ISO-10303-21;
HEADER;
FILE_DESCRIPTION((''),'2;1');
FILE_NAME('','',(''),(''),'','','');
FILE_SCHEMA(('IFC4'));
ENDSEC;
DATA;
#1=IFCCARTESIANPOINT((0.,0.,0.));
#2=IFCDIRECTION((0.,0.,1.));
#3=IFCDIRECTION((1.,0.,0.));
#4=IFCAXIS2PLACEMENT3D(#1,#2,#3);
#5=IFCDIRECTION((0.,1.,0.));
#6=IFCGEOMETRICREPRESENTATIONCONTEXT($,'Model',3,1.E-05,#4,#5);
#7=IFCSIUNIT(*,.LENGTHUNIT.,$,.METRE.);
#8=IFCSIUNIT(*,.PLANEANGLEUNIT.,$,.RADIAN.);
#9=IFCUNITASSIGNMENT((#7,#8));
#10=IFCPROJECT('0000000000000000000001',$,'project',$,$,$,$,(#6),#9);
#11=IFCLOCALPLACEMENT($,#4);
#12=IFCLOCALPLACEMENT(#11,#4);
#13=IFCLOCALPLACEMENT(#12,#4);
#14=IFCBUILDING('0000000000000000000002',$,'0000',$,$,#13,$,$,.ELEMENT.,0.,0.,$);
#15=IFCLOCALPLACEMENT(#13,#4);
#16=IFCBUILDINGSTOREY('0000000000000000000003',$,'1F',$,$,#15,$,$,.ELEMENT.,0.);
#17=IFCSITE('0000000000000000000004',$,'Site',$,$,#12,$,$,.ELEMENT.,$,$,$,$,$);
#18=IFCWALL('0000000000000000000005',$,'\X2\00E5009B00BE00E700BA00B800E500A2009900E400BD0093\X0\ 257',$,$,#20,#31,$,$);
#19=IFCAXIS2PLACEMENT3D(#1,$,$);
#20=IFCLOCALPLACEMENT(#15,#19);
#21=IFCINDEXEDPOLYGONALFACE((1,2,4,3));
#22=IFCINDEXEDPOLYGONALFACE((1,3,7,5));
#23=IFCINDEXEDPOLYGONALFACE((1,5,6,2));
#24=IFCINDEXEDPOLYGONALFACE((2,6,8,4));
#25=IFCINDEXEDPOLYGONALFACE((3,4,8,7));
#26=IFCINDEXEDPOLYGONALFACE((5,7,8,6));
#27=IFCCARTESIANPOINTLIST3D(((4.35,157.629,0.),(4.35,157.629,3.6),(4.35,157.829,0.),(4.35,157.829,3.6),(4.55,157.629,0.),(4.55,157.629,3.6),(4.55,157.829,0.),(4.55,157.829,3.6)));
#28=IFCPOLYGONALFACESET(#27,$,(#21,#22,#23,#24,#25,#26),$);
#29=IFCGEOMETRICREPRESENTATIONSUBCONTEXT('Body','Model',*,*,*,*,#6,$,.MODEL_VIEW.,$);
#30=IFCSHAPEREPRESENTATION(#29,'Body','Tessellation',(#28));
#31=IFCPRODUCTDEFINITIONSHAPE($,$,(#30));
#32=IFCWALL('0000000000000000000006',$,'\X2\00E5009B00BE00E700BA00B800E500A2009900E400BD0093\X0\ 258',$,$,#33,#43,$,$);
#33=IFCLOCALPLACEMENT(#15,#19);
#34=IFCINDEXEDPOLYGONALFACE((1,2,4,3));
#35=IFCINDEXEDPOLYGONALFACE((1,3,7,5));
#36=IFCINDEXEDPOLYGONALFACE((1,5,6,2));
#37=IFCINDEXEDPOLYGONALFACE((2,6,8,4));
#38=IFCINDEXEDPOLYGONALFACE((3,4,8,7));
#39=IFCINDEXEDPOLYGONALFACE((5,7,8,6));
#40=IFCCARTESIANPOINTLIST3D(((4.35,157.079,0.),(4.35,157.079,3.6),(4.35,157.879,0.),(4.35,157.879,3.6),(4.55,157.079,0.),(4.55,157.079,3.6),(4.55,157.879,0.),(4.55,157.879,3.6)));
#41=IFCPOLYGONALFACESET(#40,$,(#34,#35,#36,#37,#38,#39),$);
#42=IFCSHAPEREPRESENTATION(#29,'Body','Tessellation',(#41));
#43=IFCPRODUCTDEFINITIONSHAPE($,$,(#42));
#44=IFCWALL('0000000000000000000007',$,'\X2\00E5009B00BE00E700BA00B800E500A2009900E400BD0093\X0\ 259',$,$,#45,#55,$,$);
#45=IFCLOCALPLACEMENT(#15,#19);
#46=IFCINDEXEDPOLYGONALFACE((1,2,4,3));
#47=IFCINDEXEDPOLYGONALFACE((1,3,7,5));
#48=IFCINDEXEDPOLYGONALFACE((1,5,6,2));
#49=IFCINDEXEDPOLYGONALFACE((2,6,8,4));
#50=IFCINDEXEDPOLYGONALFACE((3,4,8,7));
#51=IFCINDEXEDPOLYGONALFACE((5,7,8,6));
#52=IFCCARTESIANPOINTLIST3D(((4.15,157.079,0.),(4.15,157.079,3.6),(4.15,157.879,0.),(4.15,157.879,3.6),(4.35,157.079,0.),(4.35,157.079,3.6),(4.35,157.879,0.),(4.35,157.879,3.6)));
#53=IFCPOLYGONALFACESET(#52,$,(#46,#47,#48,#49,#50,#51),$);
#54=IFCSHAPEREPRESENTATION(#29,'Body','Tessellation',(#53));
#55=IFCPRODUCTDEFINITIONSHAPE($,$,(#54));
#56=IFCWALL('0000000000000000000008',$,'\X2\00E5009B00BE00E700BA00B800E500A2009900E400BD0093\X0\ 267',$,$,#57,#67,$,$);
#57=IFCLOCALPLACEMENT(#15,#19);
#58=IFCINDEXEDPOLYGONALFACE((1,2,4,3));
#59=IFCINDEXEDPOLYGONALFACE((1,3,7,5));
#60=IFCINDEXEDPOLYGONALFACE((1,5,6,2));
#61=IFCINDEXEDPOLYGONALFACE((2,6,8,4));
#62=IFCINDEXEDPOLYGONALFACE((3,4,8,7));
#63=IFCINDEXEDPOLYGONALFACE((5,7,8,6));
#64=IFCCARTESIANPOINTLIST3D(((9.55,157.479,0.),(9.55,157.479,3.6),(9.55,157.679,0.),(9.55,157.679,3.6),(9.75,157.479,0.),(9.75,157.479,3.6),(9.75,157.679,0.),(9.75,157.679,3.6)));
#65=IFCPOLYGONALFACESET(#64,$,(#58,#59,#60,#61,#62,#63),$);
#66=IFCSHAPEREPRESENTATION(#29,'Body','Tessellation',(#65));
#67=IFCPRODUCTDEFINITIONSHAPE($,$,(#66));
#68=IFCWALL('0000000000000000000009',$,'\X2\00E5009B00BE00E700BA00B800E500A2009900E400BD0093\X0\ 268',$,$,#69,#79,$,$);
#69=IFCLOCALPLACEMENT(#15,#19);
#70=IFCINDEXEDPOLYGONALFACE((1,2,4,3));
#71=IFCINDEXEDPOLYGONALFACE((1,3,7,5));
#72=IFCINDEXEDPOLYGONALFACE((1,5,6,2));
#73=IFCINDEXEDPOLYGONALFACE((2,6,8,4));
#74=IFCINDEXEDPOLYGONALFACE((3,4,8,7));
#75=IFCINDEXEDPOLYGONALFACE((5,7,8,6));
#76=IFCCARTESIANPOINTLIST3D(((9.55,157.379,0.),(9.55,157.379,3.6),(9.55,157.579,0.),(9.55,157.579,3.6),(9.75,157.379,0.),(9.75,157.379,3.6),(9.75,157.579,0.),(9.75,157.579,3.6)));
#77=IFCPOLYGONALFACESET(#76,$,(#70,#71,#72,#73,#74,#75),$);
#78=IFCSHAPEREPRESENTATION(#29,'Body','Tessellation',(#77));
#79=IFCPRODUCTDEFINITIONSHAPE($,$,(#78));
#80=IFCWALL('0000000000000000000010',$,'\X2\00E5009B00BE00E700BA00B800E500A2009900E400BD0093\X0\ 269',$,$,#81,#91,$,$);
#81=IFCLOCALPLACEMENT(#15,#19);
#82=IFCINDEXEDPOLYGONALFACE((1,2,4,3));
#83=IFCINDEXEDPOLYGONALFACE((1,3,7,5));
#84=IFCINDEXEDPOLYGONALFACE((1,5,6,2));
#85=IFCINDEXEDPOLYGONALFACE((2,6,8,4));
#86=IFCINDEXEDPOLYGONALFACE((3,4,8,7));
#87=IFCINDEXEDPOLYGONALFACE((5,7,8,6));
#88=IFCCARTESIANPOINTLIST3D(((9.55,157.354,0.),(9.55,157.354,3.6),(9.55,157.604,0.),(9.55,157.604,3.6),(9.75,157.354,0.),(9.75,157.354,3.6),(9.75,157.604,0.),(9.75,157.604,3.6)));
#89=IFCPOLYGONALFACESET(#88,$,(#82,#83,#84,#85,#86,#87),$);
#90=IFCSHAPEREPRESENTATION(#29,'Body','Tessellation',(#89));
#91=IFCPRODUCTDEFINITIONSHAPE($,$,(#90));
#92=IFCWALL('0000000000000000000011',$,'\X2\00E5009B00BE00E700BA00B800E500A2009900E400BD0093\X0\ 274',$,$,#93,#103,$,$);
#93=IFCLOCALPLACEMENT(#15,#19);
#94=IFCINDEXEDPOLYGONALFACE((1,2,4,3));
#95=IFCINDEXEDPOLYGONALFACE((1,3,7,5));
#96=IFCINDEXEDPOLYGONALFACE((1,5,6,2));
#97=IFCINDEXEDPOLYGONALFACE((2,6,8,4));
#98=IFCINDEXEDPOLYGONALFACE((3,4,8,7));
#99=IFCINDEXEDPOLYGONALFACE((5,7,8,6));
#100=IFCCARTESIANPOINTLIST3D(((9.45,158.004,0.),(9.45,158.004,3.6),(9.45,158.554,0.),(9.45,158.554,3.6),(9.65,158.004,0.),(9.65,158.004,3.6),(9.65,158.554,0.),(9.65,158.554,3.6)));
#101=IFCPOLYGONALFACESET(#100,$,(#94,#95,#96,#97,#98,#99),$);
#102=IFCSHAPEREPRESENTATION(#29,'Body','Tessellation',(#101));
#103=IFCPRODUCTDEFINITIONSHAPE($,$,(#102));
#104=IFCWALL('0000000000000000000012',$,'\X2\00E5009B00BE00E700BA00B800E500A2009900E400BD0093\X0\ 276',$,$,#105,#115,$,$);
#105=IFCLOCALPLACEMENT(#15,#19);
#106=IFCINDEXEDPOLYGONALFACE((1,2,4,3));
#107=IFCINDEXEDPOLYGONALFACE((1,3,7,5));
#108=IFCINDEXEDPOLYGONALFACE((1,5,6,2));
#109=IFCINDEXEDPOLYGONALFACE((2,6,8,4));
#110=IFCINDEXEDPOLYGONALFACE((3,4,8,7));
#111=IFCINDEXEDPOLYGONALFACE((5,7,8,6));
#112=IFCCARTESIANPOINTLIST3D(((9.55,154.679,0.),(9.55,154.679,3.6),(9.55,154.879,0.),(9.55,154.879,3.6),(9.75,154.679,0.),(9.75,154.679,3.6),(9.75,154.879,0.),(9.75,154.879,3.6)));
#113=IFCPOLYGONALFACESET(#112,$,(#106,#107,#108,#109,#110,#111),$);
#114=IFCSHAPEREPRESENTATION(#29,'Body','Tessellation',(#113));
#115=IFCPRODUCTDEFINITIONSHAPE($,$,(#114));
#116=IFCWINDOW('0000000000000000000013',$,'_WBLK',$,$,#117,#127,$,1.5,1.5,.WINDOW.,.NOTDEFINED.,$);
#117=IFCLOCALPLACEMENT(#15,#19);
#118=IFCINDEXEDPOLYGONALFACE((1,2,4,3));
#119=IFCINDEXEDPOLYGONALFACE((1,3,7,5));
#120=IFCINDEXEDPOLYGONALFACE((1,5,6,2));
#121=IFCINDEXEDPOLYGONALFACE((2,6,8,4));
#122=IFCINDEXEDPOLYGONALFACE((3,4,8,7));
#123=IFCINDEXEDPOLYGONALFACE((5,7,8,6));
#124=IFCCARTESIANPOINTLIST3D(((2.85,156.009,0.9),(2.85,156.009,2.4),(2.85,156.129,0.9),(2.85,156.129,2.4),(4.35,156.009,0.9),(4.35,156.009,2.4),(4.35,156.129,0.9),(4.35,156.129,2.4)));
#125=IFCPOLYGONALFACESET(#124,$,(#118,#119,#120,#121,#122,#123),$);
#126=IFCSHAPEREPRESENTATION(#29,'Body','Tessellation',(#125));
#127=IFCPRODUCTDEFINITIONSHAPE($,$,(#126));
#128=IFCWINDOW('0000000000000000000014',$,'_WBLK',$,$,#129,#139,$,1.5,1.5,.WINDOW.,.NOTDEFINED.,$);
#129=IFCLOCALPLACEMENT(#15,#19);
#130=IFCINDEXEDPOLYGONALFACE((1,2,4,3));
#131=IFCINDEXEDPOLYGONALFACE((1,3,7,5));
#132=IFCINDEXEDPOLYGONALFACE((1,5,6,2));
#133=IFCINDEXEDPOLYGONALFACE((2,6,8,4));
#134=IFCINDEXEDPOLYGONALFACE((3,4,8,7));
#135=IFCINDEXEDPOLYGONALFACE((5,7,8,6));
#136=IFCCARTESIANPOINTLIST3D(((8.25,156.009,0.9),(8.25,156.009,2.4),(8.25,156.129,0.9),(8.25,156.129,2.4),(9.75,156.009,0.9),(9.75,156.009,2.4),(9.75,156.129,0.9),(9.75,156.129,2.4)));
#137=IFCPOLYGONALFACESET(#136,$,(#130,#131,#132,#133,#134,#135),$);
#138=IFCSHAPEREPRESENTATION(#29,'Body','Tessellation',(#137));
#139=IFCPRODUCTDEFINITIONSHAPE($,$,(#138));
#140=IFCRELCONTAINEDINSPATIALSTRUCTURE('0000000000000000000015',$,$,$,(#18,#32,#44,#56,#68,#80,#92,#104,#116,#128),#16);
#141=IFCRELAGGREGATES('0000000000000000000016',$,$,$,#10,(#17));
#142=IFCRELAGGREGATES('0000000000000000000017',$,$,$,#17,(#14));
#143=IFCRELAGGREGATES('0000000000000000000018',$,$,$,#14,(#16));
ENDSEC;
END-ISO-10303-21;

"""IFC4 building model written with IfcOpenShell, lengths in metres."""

from ifc_helpers import new_model, si_unit, direction, frame, frame_2d, origin_with_axes, place, context, subcontext, project, spatial, rectangle, extrude, element, save


model = new_model("IFC4")

# Units and contexts
model_context = context("Model", 3, precision=1e-05, world=origin_with_axes(), true_north=direction((0.0, 1.0, 0.0)))
body_context = subcontext(model_context, "Body", "Model", "MODEL_VIEW")
ifc_project = project(units=[si_unit("LENGTHUNIT", "METRE"), si_unit("PLANEANGLEUNIT", "RADIAN")], contexts=[model_context])

# Site, building, storey
placement = place(None, origin_with_axes())
site_placement = place(placement, origin_with_axes())
site = spatial("IfcSite", under=ifc_project, at=site_placement, Name="Site", CompositionType="ELEMENT")
building_placement = place(site_placement, origin_with_axes())
building = spatial("IfcBuilding", under=site, at=building_placement, Name="0000", CompositionType="ELEMENT", ElevationOfRefHeight=0.0, ElevationOfTerrain=0.0)
storey_placement = place(building_placement, origin_with_axes())
storey = spatial("IfcBuildingStorey", under=building, at=storey_placement, Name="1F", CompositionType="ELEMENT", Elevation=0.0)

# Walls
for number, where, z_axis, x_axis, name in (
    (1, (4.45, 157.729, 0.0), (0.0, 0.0, 1.0), (-1.0, 0.0, 0.0), "å\u009b¾çº¸å¢\u0099ä½\u0093 257"),
):
    element("IfcWall", number, at=place(storey_placement, frame(where, z_axis=z_axis, x_axis=x_axis)), inside=storey, Name=name, context=body_context, shape_type="SweptSolid", body=[
        extrude(rectangle(XDim=0.2, YDim=0.2, at=frame_2d((0.0, 0.0), x_axis=(1.0, 0.0, 0.0))), frame((0.0, 0.0, 0.0), z_axis=(0.0, 0.0, 1.0)), (0.0, 0.0, 1.0), 3.6),
    ])
for number, where, z_axis, x_axis, name in (
    (2, (4.45, 157.479, 0.0), (0.0, 0.0, 1.0), (0.0, 1.0, 0.0), "å\u009b¾çº¸å¢\u0099ä½\u0093 258"),
    (3, (4.25, 157.479, 0.0), (0.0, 0.0, 1.0), (0.0, 1.0, 0.0), "å\u009b¾çº¸å¢\u0099ä½\u0093 259"),
):
    element("IfcWall", number, at=place(storey_placement, frame(where, z_axis=z_axis, x_axis=x_axis)), inside=storey, Name=name, context=body_context, shape_type="SweptSolid", body=[
        extrude(rectangle(XDim=0.8, YDim=0.2, at=frame_2d((0.0, 0.0), x_axis=(1.0, 0.0, 0.0))), frame((0.0, 0.0, 0.0), z_axis=(0.0, 0.0, 1.0)), (0.0, 0.0, 1.0), 3.6),
    ])
for number, where, z_axis, x_axis, name in (
    (4, (9.65, 157.579, 0.0), (0.0, 0.0, 1.0), (1.0, 0.0, 0.0), "å\u009b¾çº¸å¢\u0099ä½\u0093 267"),
    (5, (9.65, 157.479, 0.0), (0.0, 0.0, 1.0), (1.0, 0.0, 0.0), "å\u009b¾çº¸å¢\u0099ä½\u0093 268"),
):
    element("IfcWall", number, at=place(storey_placement, frame(where, z_axis=z_axis, x_axis=x_axis)), inside=storey, Name=name, context=body_context, shape_type="SweptSolid", body=[
        extrude(rectangle(XDim=0.2, YDim=0.2, at=frame_2d((0.0, 0.0), x_axis=(1.0, 0.0, 0.0))), frame((0.0, 0.0, 0.0), z_axis=(0.0, 0.0, 1.0)), (0.0, 0.0, 1.0), 3.6),
    ])
wall_1_placement = place(storey_placement, frame((9.65, 157.479, 0.0), z_axis=(0.0, 0.0, 1.0), x_axis=(0.0, 1.0, 0.0)))
element("IfcWall", 6, at=wall_1_placement, inside=storey, Name="å\u009b¾çº¸å¢\u0099ä½\u0093 269", context=body_context, shape_type="SweptSolid", body=[
    extrude(rectangle(XDim=0.25, YDim=0.2, at=frame_2d((0.0, 0.0), x_axis=(1.0, 0.0, 0.0))), frame((0.0, 0.0, 0.0), z_axis=(0.0, 0.0, 1.0)), (0.0, 0.0, 1.0), 3.6),
])
wall_2_placement = place(storey_placement, frame((9.55, 158.279, 0.0), z_axis=(0.0, 0.0, 1.0), x_axis=(0.0, -1.0, 0.0)))
element("IfcWall", 7, at=wall_2_placement, inside=storey, Name="å\u009b¾çº¸å¢\u0099ä½\u0093 274", context=body_context, shape_type="SweptSolid", body=[
    extrude(rectangle(XDim=0.55, YDim=0.2, at=frame_2d((0.0, 0.0), x_axis=(1.0, 0.0, 0.0))), frame((0.0, 0.0, 0.0), z_axis=(0.0, 0.0, 1.0)), (0.0, 0.0, 1.0), 3.6),
])
wall_3_placement = place(storey_placement, frame((9.65, 154.779, 0.0), z_axis=(0.0, 0.0, 1.0), x_axis=(1.0, 0.0, 0.0)))
element("IfcWall", 8, at=wall_3_placement, inside=storey, Name="å\u009b¾çº¸å¢\u0099ä½\u0093 276", context=body_context, shape_type="SweptSolid", body=[
    extrude(rectangle(XDim=0.2, YDim=0.2, at=frame_2d((0.0, 0.0), x_axis=(1.0, 0.0, 0.0))), frame((0.0, 0.0, 0.0), z_axis=(0.0, 0.0, 1.0)), (0.0, 0.0, 1.0), 3.6),
])

# Windows
for number, where, z_axis, x_axis, name in (
    (9, (3.6, 156.069, 0.9), (0.0, 0.0, 1.0), (1.0, 0.0, 0.0), "_WBLK"),
    (10, (9.0, 156.069, 0.9), (0.0, 0.0, 1.0), (1.0, 0.0, 0.0), "_WBLK"),
):
    element("IfcWindow", number, at=place(storey_placement, frame(where, z_axis=z_axis, x_axis=x_axis)), inside=storey, Name=name, OverallHeight=1.5, OverallWidth=1.5, PartitioningType="NOTDEFINED", PredefinedType="WINDOW", context=body_context, shape_type="SweptSolid", body=[
        extrude(rectangle(XDim=1.5, YDim=0.12, at=frame_2d((0.0, 0.0), x_axis=(1.0, 0.0, 0.0))), frame((0.0, 0.0, 0.0), z_axis=(0.0, 0.0, 1.0)), (0.0, 0.0, 1.0), 1.5),
    ])

save(model, "model.ifc")
